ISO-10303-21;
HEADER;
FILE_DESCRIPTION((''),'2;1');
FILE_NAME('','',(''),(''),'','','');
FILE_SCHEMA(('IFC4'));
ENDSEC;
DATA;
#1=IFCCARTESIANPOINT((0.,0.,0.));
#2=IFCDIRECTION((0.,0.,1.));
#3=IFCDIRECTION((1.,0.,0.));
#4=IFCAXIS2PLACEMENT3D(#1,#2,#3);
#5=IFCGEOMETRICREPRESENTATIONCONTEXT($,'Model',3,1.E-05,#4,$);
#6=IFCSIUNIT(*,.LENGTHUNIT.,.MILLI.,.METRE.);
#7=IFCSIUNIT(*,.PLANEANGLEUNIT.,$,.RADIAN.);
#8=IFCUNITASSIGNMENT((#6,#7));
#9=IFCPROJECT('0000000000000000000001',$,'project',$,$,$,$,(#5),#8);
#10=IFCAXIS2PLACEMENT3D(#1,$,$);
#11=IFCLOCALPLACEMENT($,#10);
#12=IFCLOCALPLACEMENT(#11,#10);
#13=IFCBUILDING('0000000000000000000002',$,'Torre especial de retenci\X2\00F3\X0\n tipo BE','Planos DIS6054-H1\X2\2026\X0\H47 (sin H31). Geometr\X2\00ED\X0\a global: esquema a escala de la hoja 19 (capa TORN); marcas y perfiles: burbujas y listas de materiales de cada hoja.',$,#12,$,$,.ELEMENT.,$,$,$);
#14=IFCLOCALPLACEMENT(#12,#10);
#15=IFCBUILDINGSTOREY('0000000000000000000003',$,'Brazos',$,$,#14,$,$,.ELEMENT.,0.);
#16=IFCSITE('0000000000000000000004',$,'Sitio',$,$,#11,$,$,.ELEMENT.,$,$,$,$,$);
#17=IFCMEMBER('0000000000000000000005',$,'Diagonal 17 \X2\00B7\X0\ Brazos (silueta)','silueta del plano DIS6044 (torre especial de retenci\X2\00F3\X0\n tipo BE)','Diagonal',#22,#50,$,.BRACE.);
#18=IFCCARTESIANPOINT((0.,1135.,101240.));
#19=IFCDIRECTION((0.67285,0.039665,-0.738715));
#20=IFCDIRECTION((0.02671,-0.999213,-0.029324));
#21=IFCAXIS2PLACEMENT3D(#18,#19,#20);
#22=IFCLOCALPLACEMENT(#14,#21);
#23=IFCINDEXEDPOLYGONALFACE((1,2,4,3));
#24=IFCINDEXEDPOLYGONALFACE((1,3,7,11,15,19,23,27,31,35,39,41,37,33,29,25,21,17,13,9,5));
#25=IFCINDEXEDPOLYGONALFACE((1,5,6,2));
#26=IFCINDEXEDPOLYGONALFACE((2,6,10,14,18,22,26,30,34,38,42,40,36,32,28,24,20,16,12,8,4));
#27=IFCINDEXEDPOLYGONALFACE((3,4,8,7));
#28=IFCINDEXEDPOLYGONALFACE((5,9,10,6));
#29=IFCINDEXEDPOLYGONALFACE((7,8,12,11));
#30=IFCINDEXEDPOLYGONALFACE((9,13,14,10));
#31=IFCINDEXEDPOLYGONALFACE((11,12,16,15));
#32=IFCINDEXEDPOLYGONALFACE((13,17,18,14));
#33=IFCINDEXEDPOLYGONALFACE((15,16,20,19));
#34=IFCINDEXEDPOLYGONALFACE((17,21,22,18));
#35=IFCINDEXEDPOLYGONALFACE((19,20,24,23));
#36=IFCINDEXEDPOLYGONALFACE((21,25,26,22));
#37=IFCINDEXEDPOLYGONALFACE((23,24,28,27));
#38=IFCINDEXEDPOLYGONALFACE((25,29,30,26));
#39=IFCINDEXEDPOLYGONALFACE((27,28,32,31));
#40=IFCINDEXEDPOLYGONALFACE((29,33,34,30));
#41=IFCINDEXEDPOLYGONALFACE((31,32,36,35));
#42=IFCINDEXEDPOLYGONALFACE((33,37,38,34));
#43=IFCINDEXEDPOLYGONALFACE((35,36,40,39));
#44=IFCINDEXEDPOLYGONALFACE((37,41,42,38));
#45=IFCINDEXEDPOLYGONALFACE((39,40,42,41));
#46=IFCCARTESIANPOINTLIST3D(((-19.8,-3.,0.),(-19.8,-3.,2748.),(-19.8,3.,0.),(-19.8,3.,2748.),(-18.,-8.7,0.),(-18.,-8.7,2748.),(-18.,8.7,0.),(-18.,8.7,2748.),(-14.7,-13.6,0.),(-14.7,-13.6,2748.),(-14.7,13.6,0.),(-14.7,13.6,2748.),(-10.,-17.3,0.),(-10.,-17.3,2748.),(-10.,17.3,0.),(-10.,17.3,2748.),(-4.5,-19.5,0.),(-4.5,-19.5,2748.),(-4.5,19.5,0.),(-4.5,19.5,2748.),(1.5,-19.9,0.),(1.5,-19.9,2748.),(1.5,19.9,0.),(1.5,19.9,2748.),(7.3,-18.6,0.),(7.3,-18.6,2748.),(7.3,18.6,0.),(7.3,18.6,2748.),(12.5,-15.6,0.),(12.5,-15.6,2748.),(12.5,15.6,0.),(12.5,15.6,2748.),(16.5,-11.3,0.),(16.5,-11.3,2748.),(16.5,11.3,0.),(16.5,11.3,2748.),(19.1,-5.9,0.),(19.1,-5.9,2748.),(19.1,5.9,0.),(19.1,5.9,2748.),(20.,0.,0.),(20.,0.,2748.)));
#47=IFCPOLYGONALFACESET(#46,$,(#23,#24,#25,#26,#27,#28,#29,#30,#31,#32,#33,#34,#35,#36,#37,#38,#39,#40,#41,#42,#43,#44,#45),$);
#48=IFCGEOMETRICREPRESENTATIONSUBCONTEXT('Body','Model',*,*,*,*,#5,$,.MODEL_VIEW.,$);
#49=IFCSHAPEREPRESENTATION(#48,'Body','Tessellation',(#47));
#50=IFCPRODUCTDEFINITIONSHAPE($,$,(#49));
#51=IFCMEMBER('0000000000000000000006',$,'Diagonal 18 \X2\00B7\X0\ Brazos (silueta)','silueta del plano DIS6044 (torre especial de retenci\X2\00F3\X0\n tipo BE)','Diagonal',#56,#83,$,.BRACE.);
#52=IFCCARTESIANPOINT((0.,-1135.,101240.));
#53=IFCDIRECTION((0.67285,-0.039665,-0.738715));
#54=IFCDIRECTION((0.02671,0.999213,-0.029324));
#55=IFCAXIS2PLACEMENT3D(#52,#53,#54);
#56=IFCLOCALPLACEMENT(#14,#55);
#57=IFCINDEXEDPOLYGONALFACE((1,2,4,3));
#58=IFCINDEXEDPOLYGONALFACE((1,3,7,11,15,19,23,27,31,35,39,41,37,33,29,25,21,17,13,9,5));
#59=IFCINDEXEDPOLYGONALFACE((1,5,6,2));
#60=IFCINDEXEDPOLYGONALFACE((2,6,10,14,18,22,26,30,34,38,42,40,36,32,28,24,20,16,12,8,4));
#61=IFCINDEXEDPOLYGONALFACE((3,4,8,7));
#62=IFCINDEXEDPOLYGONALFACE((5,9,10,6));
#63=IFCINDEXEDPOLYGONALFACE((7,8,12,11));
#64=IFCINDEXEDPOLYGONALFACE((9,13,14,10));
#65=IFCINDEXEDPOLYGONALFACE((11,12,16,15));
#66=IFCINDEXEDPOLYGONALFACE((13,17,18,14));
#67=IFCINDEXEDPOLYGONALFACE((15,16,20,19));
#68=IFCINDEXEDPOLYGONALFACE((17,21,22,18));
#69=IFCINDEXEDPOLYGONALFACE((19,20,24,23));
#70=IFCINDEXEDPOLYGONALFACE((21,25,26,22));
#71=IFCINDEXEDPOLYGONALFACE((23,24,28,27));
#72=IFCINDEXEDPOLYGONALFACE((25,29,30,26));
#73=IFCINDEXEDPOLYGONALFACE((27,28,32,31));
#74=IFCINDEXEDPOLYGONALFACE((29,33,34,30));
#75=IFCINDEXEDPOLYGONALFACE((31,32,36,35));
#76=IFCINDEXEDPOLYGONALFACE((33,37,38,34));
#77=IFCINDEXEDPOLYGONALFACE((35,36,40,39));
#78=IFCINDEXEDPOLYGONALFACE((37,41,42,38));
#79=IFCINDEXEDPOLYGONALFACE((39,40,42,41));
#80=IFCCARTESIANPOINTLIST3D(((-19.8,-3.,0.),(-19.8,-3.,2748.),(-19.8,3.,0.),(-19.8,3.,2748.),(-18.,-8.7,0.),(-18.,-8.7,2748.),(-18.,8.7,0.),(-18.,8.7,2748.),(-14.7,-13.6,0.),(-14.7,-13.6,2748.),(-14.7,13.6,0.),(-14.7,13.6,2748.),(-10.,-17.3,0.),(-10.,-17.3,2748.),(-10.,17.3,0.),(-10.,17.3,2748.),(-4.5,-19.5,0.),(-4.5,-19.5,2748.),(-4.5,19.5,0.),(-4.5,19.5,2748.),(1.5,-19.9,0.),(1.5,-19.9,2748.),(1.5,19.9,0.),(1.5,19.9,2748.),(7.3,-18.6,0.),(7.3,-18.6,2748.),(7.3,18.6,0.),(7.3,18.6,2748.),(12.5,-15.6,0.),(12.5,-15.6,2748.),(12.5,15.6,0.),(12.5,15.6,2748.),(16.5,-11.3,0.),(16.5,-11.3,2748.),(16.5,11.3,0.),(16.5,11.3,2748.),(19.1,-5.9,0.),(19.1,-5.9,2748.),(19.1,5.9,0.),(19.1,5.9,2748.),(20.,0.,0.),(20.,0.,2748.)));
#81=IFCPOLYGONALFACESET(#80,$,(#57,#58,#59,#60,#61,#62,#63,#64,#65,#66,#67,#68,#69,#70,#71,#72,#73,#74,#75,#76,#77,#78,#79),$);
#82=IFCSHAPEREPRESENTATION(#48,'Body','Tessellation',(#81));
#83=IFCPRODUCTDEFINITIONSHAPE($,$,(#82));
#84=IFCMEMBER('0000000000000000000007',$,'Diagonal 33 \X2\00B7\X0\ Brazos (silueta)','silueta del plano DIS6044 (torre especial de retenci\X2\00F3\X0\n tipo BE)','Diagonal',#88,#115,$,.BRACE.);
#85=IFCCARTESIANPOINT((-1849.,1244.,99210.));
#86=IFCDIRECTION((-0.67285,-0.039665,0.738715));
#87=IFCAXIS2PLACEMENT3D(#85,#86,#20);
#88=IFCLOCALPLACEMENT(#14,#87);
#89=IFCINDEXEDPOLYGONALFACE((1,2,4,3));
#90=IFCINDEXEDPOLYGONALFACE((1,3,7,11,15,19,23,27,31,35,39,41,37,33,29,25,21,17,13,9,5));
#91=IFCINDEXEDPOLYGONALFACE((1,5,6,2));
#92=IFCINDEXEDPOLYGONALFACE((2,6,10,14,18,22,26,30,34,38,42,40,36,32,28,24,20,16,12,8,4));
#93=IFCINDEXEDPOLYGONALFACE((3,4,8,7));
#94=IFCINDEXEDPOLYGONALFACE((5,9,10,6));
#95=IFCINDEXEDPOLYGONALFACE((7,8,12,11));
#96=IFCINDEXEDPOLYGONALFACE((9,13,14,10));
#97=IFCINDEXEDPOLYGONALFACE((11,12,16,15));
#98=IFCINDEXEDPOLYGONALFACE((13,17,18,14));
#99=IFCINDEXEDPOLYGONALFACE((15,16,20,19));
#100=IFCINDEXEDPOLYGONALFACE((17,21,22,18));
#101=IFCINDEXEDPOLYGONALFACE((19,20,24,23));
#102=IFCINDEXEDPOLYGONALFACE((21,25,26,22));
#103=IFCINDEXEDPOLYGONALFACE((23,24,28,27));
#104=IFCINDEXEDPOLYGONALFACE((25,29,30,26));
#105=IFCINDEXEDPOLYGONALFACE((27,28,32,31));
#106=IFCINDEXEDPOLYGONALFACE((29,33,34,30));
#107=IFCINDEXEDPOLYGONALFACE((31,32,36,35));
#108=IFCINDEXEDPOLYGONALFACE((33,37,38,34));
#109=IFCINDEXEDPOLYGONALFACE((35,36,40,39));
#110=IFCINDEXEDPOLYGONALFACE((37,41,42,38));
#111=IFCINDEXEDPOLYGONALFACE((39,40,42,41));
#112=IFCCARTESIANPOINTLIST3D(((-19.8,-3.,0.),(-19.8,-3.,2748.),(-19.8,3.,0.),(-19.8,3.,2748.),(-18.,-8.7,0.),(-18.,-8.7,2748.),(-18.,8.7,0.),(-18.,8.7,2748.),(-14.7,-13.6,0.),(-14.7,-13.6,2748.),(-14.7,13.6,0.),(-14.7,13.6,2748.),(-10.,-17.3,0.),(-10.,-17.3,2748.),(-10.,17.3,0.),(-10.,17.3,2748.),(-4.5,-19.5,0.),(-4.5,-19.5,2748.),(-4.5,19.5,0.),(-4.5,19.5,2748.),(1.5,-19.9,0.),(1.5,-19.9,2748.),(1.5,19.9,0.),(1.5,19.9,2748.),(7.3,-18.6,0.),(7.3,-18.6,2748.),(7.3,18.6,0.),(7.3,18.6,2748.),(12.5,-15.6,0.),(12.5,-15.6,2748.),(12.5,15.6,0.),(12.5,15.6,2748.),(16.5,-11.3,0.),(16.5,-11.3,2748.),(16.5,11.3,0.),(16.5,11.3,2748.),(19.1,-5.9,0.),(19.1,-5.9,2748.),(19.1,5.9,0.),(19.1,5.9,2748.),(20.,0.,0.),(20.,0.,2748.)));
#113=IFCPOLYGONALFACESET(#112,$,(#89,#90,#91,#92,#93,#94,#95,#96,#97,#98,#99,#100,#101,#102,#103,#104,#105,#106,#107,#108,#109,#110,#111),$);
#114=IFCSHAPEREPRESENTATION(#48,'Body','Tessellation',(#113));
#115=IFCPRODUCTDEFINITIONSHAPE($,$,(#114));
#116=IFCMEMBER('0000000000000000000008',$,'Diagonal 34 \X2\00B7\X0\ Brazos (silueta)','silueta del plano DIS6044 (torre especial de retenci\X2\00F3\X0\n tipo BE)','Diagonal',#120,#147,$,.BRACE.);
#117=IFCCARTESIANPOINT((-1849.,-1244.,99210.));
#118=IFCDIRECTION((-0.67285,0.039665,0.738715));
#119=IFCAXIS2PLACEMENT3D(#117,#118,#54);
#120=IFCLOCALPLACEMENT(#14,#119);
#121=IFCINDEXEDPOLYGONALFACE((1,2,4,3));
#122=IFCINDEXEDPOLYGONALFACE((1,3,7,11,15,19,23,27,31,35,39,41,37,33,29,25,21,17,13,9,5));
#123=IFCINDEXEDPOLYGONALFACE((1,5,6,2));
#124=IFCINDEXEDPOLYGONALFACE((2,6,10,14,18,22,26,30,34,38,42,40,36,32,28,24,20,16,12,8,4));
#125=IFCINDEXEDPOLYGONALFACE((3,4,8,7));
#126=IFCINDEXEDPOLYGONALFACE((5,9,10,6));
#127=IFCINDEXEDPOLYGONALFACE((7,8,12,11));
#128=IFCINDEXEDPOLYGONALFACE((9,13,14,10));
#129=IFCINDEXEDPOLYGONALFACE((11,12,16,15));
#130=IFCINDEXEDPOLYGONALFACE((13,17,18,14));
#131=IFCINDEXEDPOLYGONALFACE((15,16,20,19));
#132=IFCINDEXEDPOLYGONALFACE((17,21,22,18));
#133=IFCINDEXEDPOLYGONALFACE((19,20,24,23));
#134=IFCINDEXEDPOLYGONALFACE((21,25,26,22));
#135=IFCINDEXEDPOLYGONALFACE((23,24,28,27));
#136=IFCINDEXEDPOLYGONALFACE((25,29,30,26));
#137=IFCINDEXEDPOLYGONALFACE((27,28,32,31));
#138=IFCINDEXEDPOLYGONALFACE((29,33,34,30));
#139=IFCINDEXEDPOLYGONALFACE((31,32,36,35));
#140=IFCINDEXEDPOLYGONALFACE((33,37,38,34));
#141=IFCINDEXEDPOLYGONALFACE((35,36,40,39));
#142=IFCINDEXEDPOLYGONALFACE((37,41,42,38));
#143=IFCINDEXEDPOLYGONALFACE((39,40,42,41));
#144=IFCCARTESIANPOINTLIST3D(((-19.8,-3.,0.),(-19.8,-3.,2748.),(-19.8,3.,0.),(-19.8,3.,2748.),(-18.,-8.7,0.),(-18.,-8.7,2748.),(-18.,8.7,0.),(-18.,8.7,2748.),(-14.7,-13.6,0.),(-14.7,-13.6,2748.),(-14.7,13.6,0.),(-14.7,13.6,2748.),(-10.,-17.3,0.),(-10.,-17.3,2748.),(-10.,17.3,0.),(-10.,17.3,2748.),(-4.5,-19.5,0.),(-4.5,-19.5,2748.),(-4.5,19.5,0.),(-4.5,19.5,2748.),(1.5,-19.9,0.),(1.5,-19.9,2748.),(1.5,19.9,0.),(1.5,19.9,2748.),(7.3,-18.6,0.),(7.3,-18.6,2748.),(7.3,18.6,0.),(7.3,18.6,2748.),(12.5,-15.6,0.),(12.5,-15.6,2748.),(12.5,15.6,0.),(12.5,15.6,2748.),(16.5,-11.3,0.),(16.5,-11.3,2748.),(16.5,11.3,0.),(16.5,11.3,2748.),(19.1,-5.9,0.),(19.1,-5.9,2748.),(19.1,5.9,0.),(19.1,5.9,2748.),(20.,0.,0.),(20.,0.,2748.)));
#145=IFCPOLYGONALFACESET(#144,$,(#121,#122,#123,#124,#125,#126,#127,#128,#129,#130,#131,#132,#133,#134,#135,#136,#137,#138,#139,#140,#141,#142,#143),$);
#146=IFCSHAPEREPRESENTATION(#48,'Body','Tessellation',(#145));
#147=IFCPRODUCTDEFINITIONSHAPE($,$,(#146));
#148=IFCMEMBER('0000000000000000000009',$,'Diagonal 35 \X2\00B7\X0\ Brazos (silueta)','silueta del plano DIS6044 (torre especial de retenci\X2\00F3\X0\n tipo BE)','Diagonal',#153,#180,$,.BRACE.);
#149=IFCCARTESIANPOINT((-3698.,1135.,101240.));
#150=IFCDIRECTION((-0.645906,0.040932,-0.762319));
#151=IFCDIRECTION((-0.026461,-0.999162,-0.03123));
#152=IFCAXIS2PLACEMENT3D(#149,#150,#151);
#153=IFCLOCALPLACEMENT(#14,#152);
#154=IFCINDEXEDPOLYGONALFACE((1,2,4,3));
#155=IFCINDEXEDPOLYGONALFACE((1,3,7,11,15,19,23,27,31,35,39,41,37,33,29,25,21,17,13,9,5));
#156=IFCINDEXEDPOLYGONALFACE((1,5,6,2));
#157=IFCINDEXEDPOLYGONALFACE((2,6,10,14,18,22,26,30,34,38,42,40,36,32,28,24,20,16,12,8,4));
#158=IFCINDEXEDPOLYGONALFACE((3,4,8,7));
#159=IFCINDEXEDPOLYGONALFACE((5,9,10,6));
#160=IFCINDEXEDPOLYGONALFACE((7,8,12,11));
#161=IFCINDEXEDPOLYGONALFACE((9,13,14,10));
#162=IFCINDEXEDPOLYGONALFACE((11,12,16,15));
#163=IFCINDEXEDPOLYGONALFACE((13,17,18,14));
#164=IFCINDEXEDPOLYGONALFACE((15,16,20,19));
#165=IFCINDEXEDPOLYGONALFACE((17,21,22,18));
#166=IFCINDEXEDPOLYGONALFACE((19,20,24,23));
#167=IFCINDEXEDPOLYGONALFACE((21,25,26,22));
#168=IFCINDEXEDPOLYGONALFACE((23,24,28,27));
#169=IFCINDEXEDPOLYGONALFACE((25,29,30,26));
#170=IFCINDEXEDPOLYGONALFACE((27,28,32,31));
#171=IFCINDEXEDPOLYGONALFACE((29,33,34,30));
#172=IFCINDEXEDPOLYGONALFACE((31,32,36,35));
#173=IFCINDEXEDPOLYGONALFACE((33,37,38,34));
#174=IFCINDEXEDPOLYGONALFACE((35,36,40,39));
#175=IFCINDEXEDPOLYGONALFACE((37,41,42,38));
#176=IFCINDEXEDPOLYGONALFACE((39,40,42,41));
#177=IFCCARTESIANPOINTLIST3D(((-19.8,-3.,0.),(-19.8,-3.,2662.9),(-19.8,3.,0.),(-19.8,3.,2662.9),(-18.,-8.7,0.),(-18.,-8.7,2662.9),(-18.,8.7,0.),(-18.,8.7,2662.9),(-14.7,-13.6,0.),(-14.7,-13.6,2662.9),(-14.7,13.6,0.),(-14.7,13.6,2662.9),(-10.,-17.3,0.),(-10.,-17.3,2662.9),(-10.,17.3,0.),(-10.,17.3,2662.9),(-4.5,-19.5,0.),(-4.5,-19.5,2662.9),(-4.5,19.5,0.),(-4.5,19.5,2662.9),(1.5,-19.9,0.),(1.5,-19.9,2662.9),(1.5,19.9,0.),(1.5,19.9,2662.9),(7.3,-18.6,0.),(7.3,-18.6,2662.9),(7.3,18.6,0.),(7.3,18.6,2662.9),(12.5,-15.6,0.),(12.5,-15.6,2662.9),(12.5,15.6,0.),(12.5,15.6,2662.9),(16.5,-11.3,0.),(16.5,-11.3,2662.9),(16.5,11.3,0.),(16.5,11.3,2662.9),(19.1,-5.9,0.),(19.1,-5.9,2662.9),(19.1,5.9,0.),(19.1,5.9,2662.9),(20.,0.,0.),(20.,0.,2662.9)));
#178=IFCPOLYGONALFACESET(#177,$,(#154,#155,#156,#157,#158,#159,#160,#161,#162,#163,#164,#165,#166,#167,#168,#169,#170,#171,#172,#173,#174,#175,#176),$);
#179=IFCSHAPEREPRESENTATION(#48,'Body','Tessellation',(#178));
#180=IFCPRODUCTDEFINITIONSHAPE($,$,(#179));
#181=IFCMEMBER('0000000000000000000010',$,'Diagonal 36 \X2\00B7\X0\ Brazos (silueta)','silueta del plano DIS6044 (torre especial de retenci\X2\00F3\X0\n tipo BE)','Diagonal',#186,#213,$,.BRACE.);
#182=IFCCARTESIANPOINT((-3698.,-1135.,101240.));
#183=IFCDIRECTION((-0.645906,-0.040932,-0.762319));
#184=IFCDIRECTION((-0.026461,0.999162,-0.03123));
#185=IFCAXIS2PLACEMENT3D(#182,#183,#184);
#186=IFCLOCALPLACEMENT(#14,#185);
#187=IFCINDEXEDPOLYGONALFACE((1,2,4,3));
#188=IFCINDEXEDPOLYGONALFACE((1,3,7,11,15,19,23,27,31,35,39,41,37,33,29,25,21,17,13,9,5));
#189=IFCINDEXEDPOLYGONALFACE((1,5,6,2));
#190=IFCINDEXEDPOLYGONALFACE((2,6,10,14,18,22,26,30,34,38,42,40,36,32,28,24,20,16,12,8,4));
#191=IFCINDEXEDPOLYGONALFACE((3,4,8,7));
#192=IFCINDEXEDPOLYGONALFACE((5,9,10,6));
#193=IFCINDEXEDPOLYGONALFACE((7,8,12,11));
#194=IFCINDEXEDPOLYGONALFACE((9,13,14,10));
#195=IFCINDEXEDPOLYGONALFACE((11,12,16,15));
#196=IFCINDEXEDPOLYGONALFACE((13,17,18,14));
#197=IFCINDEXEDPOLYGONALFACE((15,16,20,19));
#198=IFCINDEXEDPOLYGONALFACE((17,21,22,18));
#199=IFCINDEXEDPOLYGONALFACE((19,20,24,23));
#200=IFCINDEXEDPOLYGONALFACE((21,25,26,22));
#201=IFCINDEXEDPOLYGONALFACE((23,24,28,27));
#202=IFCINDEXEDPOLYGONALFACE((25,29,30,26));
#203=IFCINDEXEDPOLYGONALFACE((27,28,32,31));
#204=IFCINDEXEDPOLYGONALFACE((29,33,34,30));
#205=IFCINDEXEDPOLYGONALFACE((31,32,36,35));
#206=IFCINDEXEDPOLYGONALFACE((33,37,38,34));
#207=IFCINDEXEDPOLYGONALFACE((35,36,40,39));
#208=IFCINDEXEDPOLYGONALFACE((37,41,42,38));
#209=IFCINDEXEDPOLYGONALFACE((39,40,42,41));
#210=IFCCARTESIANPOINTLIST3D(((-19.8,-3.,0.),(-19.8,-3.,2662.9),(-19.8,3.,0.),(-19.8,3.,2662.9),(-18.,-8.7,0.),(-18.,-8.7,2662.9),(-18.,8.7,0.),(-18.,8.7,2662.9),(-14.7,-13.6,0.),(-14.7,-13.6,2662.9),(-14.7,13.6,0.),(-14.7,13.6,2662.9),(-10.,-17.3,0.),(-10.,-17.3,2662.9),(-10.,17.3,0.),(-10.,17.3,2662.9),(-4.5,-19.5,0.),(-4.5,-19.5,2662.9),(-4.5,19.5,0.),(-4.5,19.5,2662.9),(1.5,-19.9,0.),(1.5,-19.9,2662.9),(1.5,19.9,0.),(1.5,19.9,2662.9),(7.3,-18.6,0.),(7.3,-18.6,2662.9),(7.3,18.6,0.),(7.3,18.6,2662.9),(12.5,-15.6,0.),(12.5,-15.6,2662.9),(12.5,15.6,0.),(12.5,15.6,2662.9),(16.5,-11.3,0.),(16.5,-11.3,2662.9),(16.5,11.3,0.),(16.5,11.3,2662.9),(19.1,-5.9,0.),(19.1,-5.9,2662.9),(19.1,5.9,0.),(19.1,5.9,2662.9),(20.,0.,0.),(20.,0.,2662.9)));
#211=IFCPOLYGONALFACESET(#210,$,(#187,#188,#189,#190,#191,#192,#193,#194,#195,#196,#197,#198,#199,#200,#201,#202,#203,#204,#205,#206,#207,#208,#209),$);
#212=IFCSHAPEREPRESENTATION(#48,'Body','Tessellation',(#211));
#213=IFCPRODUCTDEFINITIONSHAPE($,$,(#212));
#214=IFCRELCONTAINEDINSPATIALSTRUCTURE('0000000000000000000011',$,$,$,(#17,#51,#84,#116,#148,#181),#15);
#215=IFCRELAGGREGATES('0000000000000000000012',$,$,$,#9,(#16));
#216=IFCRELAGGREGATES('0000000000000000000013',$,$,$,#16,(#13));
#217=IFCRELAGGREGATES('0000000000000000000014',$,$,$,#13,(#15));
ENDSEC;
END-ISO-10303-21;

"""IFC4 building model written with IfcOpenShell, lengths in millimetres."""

from ifc_helpers import new_model, si_unit, frame, origin, origin_with_axes, place, context, subcontext, project, spatial, circle, extrude, element, save


model = new_model("IFC4")

# Units and contexts
model_context = context("Model", 3, precision=1e-05, world=origin_with_axes())
body_context = subcontext(model_context, "Body", "Model", "MODEL_VIEW")
ifc_project = project(units=[si_unit("LENGTHUNIT", "METRE", prefix="MILLI"), si_unit("PLANEANGLEUNIT", "RADIAN")], contexts=[model_context])

# Site, building, storey
site_placement = place(None, origin())
site = spatial("IfcSite", under=ifc_project, at=site_placement, Name="Sitio", CompositionType="ELEMENT")
building_placement = place(site_placement, origin())
building = spatial("IfcBuilding", under=site, at=building_placement, Name="Torre especial de retención tipo BE", Description="Planos DIS6054-H1…H47 (sin H31). Geometría global: esquema a escala de la hoja 19 (capa TORN); marcas y perfiles: burbujas y listas de materiales de cada hoja.", CompositionType="ELEMENT")
storey_placement = place(building_placement, origin())
storey = spatial("IfcBuildingStorey", under=building, at=storey_placement, Name="Brazos", CompositionType="ELEMENT", Elevation=0.0)

# Members
for number, where, z_axis, x_axis, name in (
    (1, (0.0, 1135.0, 101240.0), (0.67285, 0.039665, -0.738715), (0.02671, -0.999213, -0.029324), "Diagonal 17 · Brazos (silueta)"),
    (2, (0.0, -1135.0, 101240.0), (0.67285, -0.039665, -0.738715), (0.02671, 0.999213, -0.029324), "Diagonal 18 · Brazos (silueta)"),
):
    element("IfcMember", number, at=place(storey_placement, frame(where, z_axis=z_axis, x_axis=x_axis)), inside=storey, Name=name, Description="silueta del plano DIS6044 (torre especial de retención tipo BE)", ObjectType="Diagonal", PredefinedType="BRACE", context=body_context, shape_type="SweptSolid", body=[
        extrude(circle(Radius=20.0), None, (0.0, 0.0, 1.0), 2748.0),
    ])
for number, where, z_axis, x_axis, name in (
    (3, (-1849.0, 1244.0, 99210.0), (-0.67285, -0.039665, 0.738715), (0.02671, -0.999213, -0.029324), "Diagonal 33 · Brazos (silueta)"),
    (4, (-1849.0, -1244.0, 99210.0), (-0.67285, 0.039665, 0.738715), (0.02671, 0.999213, -0.029324), "Diagonal 34 · Brazos (silueta)"),
):
    element("IfcMember", number, at=place(storey_placement, frame(where, z_axis=z_axis, x_axis=x_axis)), inside=storey, Name=name, Description="silueta del plano DIS6044 (torre especial de retención tipo BE)", ObjectType="Diagonal", PredefinedType="BRACE", context=body_context, shape_type="SweptSolid", body=[
        extrude(circle(Radius=20.0), None, (0.0, 0.0, 1.0), 2748.0),
    ])
for number, where, z_axis, x_axis, name in (
    (5, (-3698.0, 1135.0, 101240.0), (-0.645906, 0.040932, -0.762319), (-0.026461, -0.999162, -0.03123), "Diagonal 35 · Brazos (silueta)"),
    (6, (-3698.0, -1135.0, 101240.0), (-0.645906, -0.040932, -0.762319), (-0.026461, 0.999162, -0.03123), "Diagonal 36 · Brazos (silueta)"),
):
    element("IfcMember", number, at=place(storey_placement, frame(where, z_axis=z_axis, x_axis=x_axis)), inside=storey, Name=name, Description="silueta del plano DIS6044 (torre especial de retención tipo BE)", ObjectType="Diagonal", PredefinedType="BRACE", context=body_context, shape_type="SweptSolid", body=[
        extrude(circle(Radius=20.0), None, (0.0, 0.0, 1.0), 2662.9),
    ])

save(model, "model.ifc")
